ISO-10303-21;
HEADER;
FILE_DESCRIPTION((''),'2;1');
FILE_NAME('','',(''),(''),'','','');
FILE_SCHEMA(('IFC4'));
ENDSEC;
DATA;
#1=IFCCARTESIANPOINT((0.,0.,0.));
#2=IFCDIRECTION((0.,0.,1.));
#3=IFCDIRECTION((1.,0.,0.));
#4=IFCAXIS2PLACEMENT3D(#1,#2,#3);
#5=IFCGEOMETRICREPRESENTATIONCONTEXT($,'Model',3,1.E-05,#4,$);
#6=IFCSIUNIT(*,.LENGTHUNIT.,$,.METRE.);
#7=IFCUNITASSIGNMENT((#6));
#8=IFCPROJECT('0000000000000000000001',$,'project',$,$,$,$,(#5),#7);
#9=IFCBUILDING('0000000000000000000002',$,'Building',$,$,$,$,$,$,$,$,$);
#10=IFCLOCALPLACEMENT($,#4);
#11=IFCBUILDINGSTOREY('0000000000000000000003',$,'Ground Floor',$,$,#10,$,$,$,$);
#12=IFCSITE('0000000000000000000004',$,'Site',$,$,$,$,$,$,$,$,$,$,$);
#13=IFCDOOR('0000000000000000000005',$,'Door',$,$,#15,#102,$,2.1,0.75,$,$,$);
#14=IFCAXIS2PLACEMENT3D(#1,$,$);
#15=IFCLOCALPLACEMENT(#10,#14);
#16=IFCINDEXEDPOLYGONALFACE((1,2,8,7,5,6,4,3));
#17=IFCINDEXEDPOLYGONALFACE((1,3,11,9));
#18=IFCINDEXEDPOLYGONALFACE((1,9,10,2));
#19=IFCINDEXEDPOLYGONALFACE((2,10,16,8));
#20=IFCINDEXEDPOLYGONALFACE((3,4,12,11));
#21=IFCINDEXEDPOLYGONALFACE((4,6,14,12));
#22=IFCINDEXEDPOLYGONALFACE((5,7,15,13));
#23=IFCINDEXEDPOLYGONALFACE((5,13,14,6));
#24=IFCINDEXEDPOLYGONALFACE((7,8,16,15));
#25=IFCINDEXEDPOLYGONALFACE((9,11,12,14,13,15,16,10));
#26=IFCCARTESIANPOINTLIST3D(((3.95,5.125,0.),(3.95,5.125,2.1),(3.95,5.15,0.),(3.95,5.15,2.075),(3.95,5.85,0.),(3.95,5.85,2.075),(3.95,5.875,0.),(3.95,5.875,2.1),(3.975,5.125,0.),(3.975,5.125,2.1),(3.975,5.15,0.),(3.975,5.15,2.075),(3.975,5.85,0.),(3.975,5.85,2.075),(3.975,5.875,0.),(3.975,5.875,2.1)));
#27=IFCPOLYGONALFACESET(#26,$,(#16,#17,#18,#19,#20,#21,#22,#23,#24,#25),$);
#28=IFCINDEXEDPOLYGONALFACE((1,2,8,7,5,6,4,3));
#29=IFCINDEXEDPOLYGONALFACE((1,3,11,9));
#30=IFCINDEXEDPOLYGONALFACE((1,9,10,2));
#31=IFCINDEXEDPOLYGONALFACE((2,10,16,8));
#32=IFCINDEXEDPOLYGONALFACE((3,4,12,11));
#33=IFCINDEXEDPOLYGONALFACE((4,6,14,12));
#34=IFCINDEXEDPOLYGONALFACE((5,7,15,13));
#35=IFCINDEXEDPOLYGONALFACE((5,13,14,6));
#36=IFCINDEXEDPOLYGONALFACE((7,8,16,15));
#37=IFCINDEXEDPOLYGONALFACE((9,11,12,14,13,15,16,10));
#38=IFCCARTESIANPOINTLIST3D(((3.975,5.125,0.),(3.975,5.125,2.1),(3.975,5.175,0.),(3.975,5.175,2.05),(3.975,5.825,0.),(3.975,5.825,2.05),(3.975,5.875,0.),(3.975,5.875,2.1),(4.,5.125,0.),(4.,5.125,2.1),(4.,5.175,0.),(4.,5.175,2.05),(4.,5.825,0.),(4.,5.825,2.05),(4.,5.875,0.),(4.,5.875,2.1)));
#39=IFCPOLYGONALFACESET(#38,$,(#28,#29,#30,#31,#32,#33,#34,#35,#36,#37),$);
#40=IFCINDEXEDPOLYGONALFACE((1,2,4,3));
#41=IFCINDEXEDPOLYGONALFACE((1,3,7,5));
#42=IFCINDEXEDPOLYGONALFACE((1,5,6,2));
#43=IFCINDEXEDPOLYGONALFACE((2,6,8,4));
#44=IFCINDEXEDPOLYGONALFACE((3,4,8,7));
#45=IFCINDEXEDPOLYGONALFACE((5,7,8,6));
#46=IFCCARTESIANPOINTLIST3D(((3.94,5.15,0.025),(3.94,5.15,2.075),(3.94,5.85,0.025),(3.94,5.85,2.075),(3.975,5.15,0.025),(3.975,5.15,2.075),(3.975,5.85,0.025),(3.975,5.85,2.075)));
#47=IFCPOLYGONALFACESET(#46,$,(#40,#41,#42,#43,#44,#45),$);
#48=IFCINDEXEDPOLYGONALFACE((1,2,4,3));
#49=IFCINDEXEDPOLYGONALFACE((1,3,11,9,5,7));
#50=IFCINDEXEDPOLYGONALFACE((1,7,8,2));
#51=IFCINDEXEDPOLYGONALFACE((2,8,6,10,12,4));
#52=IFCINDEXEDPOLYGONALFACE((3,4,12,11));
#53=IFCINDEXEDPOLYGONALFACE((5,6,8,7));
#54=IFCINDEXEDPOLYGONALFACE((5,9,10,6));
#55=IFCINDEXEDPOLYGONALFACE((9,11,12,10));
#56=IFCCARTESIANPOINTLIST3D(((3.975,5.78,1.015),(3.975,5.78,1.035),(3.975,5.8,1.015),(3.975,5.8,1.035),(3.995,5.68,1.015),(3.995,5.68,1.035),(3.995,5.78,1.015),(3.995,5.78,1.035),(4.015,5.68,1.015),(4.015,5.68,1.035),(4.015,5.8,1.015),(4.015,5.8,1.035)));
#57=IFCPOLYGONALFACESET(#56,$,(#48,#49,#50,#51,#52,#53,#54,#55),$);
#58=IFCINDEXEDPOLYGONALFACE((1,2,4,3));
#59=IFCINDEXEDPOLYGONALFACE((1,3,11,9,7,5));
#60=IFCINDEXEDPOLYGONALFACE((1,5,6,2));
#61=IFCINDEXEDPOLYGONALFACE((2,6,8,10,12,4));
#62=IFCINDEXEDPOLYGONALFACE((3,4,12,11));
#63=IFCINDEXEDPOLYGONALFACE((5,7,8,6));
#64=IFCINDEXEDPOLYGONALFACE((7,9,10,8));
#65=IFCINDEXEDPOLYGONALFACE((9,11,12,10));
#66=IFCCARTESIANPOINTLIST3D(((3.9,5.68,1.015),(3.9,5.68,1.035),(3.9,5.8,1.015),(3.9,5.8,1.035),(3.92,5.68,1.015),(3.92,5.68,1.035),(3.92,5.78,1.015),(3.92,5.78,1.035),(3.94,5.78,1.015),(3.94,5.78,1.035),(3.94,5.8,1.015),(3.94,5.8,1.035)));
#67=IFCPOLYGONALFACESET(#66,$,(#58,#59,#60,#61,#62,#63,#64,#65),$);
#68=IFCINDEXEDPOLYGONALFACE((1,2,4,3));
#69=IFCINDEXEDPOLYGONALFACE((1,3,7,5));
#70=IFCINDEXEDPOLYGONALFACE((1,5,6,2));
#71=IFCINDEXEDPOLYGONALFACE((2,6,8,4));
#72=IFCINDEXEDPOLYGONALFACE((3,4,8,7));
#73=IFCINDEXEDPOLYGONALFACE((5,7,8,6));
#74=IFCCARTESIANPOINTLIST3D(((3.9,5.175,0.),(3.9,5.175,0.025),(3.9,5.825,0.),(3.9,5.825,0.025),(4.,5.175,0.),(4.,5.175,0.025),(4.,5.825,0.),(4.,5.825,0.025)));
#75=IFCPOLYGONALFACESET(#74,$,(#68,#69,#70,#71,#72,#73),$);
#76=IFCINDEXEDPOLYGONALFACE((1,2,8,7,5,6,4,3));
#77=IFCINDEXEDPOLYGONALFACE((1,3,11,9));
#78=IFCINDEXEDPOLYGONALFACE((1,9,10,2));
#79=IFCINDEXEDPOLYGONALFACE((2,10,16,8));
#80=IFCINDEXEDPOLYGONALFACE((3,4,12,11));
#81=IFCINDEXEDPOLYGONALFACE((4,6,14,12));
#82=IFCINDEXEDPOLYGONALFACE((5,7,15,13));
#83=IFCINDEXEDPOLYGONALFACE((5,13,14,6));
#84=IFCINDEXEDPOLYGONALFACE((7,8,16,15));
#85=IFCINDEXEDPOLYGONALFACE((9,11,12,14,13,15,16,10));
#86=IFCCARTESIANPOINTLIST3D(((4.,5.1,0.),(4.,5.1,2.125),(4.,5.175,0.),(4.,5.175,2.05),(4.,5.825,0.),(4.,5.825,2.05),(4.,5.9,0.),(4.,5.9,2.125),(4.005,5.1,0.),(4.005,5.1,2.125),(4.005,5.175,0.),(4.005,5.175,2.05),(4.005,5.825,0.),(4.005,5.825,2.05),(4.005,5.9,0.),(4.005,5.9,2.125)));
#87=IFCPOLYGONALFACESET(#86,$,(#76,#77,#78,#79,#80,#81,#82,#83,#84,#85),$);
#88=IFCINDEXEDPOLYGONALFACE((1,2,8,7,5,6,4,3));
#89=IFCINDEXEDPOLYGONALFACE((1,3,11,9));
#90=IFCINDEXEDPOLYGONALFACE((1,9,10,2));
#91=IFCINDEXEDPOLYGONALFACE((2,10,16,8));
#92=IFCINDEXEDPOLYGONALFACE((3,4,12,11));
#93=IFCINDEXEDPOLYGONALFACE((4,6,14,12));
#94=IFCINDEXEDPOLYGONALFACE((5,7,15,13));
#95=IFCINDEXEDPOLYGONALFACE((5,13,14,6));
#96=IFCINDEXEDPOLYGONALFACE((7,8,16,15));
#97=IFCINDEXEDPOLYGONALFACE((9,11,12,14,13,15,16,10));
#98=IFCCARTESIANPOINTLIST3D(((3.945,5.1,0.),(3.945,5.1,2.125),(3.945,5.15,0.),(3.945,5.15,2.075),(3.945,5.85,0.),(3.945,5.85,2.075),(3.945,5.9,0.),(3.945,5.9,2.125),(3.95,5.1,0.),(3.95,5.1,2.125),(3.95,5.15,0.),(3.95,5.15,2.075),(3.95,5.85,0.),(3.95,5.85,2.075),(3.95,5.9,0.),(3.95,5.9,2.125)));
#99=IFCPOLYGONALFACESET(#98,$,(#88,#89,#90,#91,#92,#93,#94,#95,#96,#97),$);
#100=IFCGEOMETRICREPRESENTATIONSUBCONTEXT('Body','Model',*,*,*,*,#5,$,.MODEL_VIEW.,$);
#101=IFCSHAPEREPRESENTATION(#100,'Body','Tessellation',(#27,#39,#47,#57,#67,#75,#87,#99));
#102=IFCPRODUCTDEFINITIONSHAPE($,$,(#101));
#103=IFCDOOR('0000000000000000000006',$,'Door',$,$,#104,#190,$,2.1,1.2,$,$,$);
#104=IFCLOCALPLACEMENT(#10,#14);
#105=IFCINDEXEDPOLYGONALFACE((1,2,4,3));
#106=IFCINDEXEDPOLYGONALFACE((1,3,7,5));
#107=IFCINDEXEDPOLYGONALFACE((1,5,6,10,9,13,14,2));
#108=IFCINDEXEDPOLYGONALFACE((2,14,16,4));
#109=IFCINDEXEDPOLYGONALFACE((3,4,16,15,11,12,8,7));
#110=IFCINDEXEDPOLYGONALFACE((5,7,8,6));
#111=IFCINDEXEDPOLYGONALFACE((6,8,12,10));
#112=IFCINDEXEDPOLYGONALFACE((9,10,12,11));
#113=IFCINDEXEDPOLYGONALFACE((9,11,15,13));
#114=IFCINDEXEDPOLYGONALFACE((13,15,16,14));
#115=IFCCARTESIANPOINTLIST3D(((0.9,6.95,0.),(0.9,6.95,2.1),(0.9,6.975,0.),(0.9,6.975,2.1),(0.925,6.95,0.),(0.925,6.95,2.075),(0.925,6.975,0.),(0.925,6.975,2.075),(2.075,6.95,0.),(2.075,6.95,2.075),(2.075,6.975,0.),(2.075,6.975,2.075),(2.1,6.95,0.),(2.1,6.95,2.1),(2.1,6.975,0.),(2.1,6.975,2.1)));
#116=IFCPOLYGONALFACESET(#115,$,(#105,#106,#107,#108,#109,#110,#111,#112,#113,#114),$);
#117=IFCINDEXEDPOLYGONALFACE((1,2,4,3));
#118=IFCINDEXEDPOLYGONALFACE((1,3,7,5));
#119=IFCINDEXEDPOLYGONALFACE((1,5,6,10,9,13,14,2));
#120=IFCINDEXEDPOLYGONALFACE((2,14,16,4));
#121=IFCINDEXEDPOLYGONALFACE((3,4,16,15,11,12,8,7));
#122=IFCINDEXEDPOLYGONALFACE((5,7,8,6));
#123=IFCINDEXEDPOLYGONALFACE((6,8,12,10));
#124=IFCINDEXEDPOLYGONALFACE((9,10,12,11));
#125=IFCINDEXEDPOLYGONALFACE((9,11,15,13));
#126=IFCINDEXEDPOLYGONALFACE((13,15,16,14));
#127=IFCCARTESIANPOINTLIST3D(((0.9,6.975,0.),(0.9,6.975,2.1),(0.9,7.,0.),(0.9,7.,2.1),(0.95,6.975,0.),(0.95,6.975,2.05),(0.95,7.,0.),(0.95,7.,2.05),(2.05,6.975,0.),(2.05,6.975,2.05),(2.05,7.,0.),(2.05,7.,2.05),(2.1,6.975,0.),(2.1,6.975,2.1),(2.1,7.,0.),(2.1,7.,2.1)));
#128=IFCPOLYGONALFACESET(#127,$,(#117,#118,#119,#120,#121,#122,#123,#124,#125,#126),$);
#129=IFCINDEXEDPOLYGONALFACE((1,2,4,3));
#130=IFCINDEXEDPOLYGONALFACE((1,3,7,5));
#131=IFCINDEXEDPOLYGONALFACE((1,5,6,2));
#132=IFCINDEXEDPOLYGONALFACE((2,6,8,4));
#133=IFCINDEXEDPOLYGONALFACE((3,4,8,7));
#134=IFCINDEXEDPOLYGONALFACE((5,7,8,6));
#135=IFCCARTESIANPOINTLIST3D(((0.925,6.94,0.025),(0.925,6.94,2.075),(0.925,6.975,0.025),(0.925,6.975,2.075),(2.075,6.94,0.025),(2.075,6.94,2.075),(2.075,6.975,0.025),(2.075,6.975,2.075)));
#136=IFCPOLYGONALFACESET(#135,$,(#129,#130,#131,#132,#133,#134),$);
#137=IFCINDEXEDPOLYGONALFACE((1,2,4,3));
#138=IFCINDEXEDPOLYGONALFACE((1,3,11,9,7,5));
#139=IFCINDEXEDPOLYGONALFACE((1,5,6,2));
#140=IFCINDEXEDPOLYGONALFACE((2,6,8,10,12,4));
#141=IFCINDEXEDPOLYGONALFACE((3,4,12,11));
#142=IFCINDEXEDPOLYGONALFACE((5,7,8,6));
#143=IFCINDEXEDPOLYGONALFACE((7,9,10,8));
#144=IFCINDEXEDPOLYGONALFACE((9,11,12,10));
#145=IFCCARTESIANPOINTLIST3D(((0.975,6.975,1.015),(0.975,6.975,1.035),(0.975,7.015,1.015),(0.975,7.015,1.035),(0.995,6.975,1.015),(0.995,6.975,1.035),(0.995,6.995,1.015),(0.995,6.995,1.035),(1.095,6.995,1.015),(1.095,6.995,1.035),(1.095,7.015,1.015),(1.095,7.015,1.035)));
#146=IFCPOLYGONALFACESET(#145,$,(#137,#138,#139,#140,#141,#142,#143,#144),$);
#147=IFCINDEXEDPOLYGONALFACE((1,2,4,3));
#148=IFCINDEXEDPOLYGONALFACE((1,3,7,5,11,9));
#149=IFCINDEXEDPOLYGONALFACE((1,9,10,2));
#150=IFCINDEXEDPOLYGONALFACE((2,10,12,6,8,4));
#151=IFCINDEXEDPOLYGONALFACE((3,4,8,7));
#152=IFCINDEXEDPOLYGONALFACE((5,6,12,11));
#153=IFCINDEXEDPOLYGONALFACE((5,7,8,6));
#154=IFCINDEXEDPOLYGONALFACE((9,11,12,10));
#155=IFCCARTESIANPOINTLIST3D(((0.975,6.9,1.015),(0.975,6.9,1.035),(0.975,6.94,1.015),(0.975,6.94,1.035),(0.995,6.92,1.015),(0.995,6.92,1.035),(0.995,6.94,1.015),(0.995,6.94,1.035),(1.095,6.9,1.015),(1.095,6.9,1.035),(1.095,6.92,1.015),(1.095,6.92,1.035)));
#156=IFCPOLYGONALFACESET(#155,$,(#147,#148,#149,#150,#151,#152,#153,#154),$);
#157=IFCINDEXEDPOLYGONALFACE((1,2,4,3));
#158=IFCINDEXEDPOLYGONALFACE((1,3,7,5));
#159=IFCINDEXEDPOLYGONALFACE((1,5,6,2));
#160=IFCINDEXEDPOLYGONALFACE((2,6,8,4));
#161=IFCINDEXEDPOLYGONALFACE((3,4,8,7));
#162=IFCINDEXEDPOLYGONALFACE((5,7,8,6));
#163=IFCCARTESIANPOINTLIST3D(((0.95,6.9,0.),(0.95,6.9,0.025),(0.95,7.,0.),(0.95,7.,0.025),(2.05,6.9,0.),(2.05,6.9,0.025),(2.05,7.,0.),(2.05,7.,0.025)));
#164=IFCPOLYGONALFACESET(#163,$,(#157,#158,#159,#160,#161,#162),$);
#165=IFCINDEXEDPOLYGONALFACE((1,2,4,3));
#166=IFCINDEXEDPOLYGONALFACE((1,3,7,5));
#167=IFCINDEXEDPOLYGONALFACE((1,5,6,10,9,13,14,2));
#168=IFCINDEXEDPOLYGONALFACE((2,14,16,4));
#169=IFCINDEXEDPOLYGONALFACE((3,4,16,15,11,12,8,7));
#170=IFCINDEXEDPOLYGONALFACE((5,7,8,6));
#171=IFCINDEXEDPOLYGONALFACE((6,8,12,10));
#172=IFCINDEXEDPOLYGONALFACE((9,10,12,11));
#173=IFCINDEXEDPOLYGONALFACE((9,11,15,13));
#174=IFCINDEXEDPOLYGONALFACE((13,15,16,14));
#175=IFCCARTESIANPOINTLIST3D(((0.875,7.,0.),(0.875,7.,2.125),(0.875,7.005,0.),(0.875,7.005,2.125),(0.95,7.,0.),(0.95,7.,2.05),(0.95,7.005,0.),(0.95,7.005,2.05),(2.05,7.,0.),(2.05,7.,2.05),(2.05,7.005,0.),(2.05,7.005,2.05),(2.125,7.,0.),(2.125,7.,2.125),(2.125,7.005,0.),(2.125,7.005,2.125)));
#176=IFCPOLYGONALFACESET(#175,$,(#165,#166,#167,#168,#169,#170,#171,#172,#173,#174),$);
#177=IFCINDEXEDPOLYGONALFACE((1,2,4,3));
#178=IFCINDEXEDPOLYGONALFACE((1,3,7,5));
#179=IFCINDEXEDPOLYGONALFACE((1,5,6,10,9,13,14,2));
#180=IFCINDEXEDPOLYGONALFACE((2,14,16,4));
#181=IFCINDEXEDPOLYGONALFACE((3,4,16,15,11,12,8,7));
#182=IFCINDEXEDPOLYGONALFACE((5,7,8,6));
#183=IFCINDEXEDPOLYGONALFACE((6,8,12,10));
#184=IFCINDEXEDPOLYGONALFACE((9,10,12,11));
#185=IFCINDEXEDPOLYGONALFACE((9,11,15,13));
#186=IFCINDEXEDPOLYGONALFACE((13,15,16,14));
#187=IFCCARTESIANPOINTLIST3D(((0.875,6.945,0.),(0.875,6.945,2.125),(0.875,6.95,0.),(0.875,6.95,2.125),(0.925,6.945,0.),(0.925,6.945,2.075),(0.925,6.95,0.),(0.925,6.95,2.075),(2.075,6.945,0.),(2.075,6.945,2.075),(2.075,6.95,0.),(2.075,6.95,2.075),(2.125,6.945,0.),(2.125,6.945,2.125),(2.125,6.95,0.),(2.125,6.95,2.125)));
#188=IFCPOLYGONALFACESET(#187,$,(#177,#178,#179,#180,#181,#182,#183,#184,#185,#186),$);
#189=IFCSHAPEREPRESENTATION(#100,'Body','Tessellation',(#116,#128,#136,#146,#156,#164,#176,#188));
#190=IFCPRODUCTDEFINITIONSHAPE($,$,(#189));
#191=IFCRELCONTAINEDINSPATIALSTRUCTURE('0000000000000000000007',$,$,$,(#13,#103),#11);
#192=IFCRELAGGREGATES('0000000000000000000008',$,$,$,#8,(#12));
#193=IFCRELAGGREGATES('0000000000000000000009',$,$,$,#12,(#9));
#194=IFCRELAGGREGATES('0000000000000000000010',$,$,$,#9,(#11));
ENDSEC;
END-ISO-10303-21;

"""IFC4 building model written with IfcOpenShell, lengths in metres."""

from ifc_helpers import new_model, si_unit, frame, origin_with_axes, place, context, subcontext, project, spatial, line, indexed_curve, outline, extrude, element, save


model = new_model("IFC4")

# Units and contexts
model_context = context("Model", 3, precision=1e-05, world=origin_with_axes())
body_context = subcontext(model_context, "Body", "Model", "MODEL_VIEW")
ifc_project = project(units=[si_unit("LENGTHUNIT", "METRE")], contexts=[model_context])

# Site, building, storey
site = spatial("IfcSite", under=ifc_project, Name="Site")
building = spatial("IfcBuilding", under=site, Name="Building")
storey_placement = place(None, origin_with_axes())
storey = spatial("IfcBuildingStorey", under=building, at=storey_placement, Name="Ground Floor")

# Doors
door_1_placement = place(storey_placement, frame((4.0, 5.125, 0.0), z_axis=(0.0, 0.0, 1.0), x_axis=(0.0, 1.0, 0.0)))
element("IfcDoor", 1, at=door_1_placement, inside=storey, Name="Door", OverallHeight=2.1, OverallWidth=0.75, context=body_context, shape_type="SweptSolid", body=[
    extrude(outline(indexed_curve([(0.0, 0.0), (0.0, 2.1), (0.75, 2.1), (0.75, 0.0), (0.725, 0.0), (0.725, 2.075), (0.025, 2.075), (0.025, 0.0)], segments=[line(1, 2, 3, 4, 5, 6, 7, 8, 1)])), frame((0.0, 0.025, 0.0), z_axis=(0.0, -1.0, 0.0), x_axis=(1.0, 0.0, 0.0)), (0.0, 0.0, -1.0), 0.025),
    extrude(outline(indexed_curve([(0.0, 0.0), (0.0, 2.1), (0.75, 2.1), (0.75, 0.0), (0.7, 0.0), (0.7, 2.05), (0.05, 2.05), (0.05, 0.0)], segments=[line(1, 2, 3, 4, 5, 6, 7, 8, 1)])), frame((0.0, 0.0, 0.0), z_axis=(0.0, -1.0, 0.0), x_axis=(1.0, 0.0, 0.0)), (0.0, 0.0, -1.0), 0.025),
    extrude(outline(indexed_curve([(0.0, 0.0), (0.7, 0.0), (0.7, 0.035), (0.0, 0.035)], segments=[line(1, 2, 3, 4, 1)])), frame((0.025, 0.025, 0.025), z_axis=(0.0, 0.0, 1.0), x_axis=(1.0, 0.0, 0.0)), (0.0, 0.0, 1.0), 2.05),
    extrude(outline(indexed_curve([(0.0, 0.0), (0.0, -0.04), (-0.12, -0.04), (-0.12, -0.02), (-0.02, -0.02), (-0.02, 0.0)], segments=[line(1, 2, 3, 4, 5, 6, 1)])), frame((0.675, 0.025, 1.015), z_axis=(0.0, 0.0, 1.0), x_axis=(1.0, 0.0, 0.0)), (0.0, 0.0, 1.0), 0.02),
    extrude(outline(indexed_curve([(0.0, 0.0), (0.0, 0.04), (-0.12, 0.04), (-0.12, 0.02), (-0.02, 0.02), (-0.02, 0.0)], segments=[line(1, 2, 3, 4, 5, 6, 1)])), frame((0.675, 0.06, 1.015), z_axis=(0.0, 0.0, 1.0), x_axis=(1.0, 0.0, 0.0)), (0.0, 0.0, 1.0), 0.02),
    extrude(outline(indexed_curve([(0.0, 0.0), (0.65, 0.0), (0.65, 0.1), (0.0, 0.1)], segments=[line(1, 2, 3, 4, 1)])), frame((0.05, 0.0, 0.0), z_axis=(0.0, 0.0, 1.0), x_axis=(1.0, 0.0, 0.0)), (0.0, 0.0, 1.0), 0.025),
    extrude(outline(indexed_curve([(0.0, 0.0), (0.0, 2.125), (0.8, 2.125), (0.8, 0.0), (0.725, 0.0), (0.725, 2.05), (0.075, 2.05), (0.075, 0.0)], segments=[line(1, 2, 3, 4, 5, 6, 7, 8, 1)])), frame((-0.025, -0.005, 0.0), z_axis=(0.0, -1.0, 0.0), x_axis=(1.0, 0.0, 0.0)), (0.0, 0.0, -1.0), 0.005),
    extrude(outline(indexed_curve([(0.0, 0.0), (0.0, 2.125), (0.8, 2.125), (0.8, 0.0), (0.75, 0.0), (0.75, 2.075), (0.05, 2.075), (0.05, 0.0)], segments=[line(1, 2, 3, 4, 5, 6, 7, 8, 1)])), frame((-0.025, 0.05, 0.0), z_axis=(0.0, -1.0, 0.0), x_axis=(1.0, 0.0, 0.0)), (0.0, 0.0, -1.0), 0.005),
])
door_2_placement = place(storey_placement, frame((2.1, 7.0, 0.0), z_axis=(0.0, 0.0, 1.0), x_axis=(-1.0, 0.0, 0.0)))
element("IfcDoor", 2, at=door_2_placement, inside=storey, Name="Door", OverallHeight=2.1, OverallWidth=1.2, context=body_context, shape_type="SweptSolid", body=[
    extrude(outline(indexed_curve([(0.0, 0.0), (0.0, 2.1), (1.2, 2.1), (1.2, 0.0), (1.175, 0.0), (1.175, 2.075), (0.025, 2.075), (0.025, 0.0)], segments=[line(1, 2, 3, 4, 5, 6, 7, 8, 1)])), frame((0.0, 0.025, 0.0), z_axis=(0.0, -1.0, 0.0), x_axis=(1.0, 0.0, 0.0)), (0.0, 0.0, -1.0), 0.025),
    extrude(outline(indexed_curve([(0.0, 0.0), (0.0, 2.1), (1.2, 2.1), (1.2, 0.0), (1.15, 0.0), (1.15, 2.05), (0.05, 2.05), (0.05, 0.0)], segments=[line(1, 2, 3, 4, 5, 6, 7, 8, 1)])), frame((0.0, 0.0, 0.0), z_axis=(0.0, -1.0, 0.0), x_axis=(1.0, 0.0, 0.0)), (0.0, 0.0, -1.0), 0.025),
    extrude(outline(indexed_curve([(0.0, 0.0), (1.15, 0.0), (1.15, 0.035), (0.0, 0.035)], segments=[line(1, 2, 3, 4, 1)])), frame((0.025, 0.025, 0.025), z_axis=(0.0, 0.0, 1.0), x_axis=(1.0, 0.0, 0.0)), (0.0, 0.0, 1.0), 2.05),
    extrude(outline(indexed_curve([(0.0, 0.0), (0.0, -0.04), (-0.12, -0.04), (-0.12, -0.02), (-0.02, -0.02), (-0.02, 0.0)], segments=[line(1, 2, 3, 4, 5, 6, 1)])), frame((1.125, 0.025, 1.015), z_axis=(0.0, 0.0, 1.0), x_axis=(1.0, 0.0, 0.0)), (0.0, 0.0, 1.0), 0.02),
    extrude(outline(indexed_curve([(0.0, 0.0), (0.0, 0.04), (-0.12, 0.04), (-0.12, 0.02), (-0.02, 0.02), (-0.02, 0.0)], segments=[line(1, 2, 3, 4, 5, 6, 1)])), frame((1.125, 0.06, 1.015), z_axis=(0.0, 0.0, 1.0), x_axis=(1.0, 0.0, 0.0)), (0.0, 0.0, 1.0), 0.02),
    extrude(outline(indexed_curve([(0.0, 0.0), (1.1, 0.0), (1.1, 0.1), (0.0, 0.1)], segments=[line(1, 2, 3, 4, 1)])), frame((0.05, 0.0, 0.0), z_axis=(0.0, 0.0, 1.0), x_axis=(1.0, 0.0, 0.0)), (0.0, 0.0, 1.0), 0.025),
    extrude(outline(indexed_curve([(0.0, 0.0), (0.0, 2.125), (1.25, 2.125), (1.25, 0.0), (1.175, 0.0), (1.175, 2.05), (0.075, 2.05), (0.075, 0.0)], segments=[line(1, 2, 3, 4, 5, 6, 7, 8, 1)])), frame((-0.025, -0.005, 0.0), z_axis=(0.0, -1.0, 0.0), x_axis=(1.0, 0.0, 0.0)), (0.0, 0.0, -1.0), 0.005),
    extrude(outline(indexed_curve([(0.0, 0.0), (0.0, 2.125), (1.25, 2.125), (1.25, 0.0), (1.2, 0.0), (1.2, 2.075), (0.05, 2.075), (0.05, 0.0)], segments=[line(1, 2, 3, 4, 5, 6, 7, 8, 1)])), frame((-0.025, 0.05, 0.0), z_axis=(0.0, -1.0, 0.0), x_axis=(1.0, 0.0, 0.0)), (0.0, 0.0, -1.0), 0.005),
])

save(model, "model.ifc")
